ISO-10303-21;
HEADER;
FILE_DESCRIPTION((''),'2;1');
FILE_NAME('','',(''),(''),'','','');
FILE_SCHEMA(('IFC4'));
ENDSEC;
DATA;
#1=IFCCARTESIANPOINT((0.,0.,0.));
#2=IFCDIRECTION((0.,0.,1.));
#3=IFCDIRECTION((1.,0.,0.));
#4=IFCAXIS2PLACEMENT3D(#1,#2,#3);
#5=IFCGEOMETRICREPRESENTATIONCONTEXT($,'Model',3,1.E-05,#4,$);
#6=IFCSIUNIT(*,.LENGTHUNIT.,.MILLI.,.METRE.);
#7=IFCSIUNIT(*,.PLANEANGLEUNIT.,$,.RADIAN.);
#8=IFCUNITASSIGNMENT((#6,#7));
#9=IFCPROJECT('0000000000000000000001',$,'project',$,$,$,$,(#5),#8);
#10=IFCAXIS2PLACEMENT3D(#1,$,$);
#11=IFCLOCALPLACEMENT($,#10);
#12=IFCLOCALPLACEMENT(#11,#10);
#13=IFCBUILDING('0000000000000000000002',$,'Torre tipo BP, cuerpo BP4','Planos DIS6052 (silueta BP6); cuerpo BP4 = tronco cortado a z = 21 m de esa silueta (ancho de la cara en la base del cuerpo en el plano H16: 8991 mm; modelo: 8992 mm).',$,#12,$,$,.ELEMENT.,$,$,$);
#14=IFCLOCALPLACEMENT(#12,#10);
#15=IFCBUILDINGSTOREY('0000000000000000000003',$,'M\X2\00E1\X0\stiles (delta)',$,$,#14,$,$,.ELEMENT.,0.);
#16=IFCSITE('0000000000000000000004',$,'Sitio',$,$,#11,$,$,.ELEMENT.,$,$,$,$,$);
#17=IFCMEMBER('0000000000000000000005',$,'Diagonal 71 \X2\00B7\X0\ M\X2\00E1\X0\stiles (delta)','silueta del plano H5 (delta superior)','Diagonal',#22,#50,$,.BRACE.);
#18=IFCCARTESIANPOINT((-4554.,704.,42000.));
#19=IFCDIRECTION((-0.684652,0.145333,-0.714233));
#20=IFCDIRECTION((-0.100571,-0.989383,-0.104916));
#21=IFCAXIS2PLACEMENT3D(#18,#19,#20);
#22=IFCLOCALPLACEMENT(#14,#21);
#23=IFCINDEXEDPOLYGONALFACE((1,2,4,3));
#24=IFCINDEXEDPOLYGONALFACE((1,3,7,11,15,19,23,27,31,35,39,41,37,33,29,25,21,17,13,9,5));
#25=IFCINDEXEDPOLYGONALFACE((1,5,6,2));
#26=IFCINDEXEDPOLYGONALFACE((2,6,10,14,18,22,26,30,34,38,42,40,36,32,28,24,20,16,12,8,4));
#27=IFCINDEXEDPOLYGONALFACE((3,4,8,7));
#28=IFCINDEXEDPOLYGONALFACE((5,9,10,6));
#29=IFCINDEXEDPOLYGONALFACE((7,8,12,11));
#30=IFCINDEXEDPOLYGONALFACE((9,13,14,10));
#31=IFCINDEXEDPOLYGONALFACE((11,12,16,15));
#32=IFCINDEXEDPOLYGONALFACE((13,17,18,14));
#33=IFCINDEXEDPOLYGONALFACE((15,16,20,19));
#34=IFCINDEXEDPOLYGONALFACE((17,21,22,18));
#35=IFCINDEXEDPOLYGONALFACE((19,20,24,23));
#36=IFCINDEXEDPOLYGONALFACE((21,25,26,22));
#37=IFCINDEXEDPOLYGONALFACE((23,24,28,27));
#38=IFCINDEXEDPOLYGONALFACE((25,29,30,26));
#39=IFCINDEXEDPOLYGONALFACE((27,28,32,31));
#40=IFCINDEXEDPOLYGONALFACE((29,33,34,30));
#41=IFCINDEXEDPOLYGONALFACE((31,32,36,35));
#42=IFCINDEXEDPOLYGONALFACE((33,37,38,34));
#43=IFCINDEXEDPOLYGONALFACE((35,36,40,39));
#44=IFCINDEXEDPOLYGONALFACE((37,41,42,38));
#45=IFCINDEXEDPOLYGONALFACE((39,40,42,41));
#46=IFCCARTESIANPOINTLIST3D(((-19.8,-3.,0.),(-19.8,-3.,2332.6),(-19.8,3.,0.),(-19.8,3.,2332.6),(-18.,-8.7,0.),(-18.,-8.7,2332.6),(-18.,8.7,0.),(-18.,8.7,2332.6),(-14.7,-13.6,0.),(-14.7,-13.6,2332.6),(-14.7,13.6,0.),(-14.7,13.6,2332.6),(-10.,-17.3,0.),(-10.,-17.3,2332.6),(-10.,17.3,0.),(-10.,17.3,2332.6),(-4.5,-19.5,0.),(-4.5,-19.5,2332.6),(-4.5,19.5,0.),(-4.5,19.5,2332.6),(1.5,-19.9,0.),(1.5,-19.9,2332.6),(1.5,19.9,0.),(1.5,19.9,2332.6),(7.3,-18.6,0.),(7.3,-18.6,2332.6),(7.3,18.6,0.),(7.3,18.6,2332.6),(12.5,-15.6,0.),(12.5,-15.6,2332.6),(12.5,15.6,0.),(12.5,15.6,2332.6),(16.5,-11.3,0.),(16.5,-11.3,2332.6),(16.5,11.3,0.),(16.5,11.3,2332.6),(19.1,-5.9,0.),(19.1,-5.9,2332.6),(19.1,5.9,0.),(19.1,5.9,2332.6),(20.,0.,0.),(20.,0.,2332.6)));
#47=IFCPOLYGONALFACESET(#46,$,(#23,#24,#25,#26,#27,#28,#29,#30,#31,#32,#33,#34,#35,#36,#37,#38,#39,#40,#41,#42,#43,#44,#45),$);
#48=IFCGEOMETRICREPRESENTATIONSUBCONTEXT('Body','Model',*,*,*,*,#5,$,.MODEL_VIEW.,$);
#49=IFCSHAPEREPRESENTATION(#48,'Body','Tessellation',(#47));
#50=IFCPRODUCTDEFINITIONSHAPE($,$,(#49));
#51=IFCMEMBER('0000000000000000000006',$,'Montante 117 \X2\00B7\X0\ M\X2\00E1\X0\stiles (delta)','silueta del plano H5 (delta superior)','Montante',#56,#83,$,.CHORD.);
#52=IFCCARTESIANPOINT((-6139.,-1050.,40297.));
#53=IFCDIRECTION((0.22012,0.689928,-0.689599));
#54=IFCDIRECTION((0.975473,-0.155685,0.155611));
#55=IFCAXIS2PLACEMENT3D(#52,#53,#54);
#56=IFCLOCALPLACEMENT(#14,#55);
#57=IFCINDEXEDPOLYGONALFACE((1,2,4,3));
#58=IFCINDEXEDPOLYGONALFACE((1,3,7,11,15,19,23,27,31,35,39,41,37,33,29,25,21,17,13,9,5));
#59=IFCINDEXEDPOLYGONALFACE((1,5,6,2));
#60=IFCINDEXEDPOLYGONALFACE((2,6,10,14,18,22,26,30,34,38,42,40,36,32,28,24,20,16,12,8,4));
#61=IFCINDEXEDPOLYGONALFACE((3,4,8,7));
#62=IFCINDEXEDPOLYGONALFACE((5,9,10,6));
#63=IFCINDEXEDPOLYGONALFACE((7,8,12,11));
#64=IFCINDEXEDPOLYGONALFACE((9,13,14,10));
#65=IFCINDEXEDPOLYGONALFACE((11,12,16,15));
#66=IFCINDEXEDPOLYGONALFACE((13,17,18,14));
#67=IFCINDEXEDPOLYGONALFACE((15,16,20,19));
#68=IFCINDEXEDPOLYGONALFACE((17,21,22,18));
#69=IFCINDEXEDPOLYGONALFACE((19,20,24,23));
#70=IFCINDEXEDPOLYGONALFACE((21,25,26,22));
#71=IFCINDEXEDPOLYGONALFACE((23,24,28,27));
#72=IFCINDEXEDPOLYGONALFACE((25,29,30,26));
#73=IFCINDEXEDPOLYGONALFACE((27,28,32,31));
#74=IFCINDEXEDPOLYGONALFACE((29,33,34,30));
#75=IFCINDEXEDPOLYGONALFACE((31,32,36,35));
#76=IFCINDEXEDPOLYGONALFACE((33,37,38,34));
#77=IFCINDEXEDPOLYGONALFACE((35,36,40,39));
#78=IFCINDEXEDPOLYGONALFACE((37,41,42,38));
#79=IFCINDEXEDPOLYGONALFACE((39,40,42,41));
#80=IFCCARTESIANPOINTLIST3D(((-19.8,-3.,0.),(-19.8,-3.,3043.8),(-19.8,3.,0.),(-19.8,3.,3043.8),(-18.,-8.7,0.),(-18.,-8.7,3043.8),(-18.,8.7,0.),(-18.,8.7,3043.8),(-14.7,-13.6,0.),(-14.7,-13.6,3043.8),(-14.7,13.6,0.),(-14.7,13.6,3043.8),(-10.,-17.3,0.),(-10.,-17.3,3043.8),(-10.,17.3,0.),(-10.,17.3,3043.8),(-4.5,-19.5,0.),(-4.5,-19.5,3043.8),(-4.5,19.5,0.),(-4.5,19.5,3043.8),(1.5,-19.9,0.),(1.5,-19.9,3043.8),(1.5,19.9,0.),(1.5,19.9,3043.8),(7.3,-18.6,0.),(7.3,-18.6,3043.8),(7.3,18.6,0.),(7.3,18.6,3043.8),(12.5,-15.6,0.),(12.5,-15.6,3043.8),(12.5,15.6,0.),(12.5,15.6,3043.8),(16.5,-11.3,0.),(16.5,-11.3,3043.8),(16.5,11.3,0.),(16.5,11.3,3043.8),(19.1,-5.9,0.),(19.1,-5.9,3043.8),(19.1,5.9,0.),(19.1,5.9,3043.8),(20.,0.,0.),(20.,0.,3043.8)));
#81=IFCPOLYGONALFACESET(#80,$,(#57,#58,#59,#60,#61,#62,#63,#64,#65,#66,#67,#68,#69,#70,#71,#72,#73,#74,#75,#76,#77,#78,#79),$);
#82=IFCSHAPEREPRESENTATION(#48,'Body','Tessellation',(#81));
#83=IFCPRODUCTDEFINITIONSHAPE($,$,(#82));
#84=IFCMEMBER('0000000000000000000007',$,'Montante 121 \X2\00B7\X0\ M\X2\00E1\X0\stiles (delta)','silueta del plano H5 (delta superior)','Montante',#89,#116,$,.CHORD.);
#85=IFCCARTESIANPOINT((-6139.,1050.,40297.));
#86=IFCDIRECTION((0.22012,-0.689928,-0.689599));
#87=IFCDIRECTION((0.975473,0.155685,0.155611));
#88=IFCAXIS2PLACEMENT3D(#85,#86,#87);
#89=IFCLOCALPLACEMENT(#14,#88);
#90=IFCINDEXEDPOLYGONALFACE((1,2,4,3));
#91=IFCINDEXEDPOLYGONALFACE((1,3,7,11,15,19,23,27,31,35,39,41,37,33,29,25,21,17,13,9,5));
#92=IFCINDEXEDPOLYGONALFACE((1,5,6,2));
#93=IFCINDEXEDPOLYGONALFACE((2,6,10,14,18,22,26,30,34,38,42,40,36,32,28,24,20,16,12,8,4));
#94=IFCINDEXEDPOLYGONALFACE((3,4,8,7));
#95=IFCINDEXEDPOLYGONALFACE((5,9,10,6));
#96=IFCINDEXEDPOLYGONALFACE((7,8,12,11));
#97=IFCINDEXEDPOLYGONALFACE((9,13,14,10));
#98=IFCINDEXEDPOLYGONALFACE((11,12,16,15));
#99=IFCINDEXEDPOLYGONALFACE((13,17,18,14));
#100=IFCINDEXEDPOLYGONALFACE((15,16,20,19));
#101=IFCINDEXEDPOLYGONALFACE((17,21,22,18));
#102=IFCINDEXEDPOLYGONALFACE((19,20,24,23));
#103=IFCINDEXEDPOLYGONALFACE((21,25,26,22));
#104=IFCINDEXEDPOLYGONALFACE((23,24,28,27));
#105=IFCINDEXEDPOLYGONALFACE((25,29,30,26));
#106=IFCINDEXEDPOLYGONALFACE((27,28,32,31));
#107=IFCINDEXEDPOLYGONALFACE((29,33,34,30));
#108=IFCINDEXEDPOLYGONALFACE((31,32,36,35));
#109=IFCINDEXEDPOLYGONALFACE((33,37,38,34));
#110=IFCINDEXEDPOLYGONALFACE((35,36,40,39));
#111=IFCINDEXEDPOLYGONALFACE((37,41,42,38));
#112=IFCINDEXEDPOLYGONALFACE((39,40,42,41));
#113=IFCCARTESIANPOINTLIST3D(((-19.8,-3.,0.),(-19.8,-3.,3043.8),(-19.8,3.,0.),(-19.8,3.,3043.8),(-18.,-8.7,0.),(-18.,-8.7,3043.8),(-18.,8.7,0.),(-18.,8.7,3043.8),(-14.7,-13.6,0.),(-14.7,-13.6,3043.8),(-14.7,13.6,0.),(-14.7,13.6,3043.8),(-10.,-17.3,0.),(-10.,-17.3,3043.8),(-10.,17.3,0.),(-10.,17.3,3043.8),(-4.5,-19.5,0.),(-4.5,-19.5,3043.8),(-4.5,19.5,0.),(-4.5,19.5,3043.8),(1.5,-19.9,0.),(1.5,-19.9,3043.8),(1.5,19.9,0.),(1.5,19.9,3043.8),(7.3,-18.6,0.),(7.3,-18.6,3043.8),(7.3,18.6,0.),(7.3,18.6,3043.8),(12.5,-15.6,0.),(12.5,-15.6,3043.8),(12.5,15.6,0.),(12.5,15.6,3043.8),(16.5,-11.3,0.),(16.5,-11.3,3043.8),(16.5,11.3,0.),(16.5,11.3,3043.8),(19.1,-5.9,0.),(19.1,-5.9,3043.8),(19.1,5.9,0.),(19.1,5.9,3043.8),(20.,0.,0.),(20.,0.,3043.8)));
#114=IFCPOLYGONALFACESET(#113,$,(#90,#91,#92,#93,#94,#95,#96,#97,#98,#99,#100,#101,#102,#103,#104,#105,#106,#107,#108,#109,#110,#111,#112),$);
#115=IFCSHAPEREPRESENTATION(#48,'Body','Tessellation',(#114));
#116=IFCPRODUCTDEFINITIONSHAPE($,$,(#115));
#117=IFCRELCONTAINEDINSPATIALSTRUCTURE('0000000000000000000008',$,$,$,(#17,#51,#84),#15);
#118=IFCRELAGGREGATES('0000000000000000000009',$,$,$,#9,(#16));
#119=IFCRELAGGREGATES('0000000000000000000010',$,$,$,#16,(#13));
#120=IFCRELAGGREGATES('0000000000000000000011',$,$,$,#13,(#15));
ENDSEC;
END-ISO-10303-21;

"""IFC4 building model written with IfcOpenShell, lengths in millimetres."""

from ifc_helpers import new_model, si_unit, frame, origin, origin_with_axes, place, context, subcontext, project, spatial, circle, extrude, element, save


model = new_model("IFC4")

# Units and contexts
model_context = context("Model", 3, precision=1e-05, world=origin_with_axes())
body_context = subcontext(model_context, "Body", "Model", "MODEL_VIEW")
ifc_project = project(units=[si_unit("LENGTHUNIT", "METRE", prefix="MILLI"), si_unit("PLANEANGLEUNIT", "RADIAN")], contexts=[model_context])

# Site, building, storey
site_placement = place(None, origin())
site = spatial("IfcSite", under=ifc_project, at=site_placement, Name="Sitio", CompositionType="ELEMENT")
building_placement = place(site_placement, origin())
building = spatial("IfcBuilding", under=site, at=building_placement, Name="Torre tipo BP, cuerpo BP4", Description="Planos DIS6052 (silueta BP6); cuerpo BP4 = tronco cortado a z = 21 m de esa silueta (ancho de la cara en la base del cuerpo en el plano H16: 8991 mm; modelo: 8992 mm).", CompositionType="ELEMENT")
storey_placement = place(building_placement, origin())
storey = spatial("IfcBuildingStorey", under=building, at=storey_placement, Name="Mástiles (delta)", CompositionType="ELEMENT", Elevation=0.0)

# Members
member_1_placement = place(storey_placement, frame((-4554.0, 704.0, 42000.0), z_axis=(-0.684652, 0.145333, -0.714233), x_axis=(-0.100571, -0.989383, -0.104916)))
element("IfcMember", 1, at=member_1_placement, inside=storey, Name="Diagonal 71 · Mástiles (delta)", Description="silueta del plano H5 (delta superior)", ObjectType="Diagonal", PredefinedType="BRACE", context=body_context, shape_type="SweptSolid", body=[
    extrude(circle(Radius=20.0), None, (0.0, 0.0, 1.0), 2332.6),
])
member_2_placement = place(storey_placement, frame((-6139.0, -1050.0, 40297.0), z_axis=(0.22012, 0.689928, -0.689599), x_axis=(0.975473, -0.155685, 0.155611)))
element("IfcMember", 2, at=member_2_placement, inside=storey, Name="Montante 117 · Mástiles (delta)", Description="silueta del plano H5 (delta superior)", ObjectType="Montante", PredefinedType="CHORD", context=body_context, shape_type="SweptSolid", body=[
    extrude(circle(Radius=20.0), None, (0.0, 0.0, 1.0), 3043.8),
])
member_3_placement = place(storey_placement, frame((-6139.0, 1050.0, 40297.0), z_axis=(0.22012, -0.689928, -0.689599), x_axis=(0.975473, 0.155685, 0.155611)))
element("IfcMember", 3, at=member_3_placement, inside=storey, Name="Montante 121 · Mástiles (delta)", Description="silueta del plano H5 (delta superior)", ObjectType="Montante", PredefinedType="CHORD", context=body_context, shape_type="SweptSolid", body=[
    extrude(circle(Radius=20.0), None, (0.0, 0.0, 1.0), 3043.8),
])

save(model, "model.ifc")
